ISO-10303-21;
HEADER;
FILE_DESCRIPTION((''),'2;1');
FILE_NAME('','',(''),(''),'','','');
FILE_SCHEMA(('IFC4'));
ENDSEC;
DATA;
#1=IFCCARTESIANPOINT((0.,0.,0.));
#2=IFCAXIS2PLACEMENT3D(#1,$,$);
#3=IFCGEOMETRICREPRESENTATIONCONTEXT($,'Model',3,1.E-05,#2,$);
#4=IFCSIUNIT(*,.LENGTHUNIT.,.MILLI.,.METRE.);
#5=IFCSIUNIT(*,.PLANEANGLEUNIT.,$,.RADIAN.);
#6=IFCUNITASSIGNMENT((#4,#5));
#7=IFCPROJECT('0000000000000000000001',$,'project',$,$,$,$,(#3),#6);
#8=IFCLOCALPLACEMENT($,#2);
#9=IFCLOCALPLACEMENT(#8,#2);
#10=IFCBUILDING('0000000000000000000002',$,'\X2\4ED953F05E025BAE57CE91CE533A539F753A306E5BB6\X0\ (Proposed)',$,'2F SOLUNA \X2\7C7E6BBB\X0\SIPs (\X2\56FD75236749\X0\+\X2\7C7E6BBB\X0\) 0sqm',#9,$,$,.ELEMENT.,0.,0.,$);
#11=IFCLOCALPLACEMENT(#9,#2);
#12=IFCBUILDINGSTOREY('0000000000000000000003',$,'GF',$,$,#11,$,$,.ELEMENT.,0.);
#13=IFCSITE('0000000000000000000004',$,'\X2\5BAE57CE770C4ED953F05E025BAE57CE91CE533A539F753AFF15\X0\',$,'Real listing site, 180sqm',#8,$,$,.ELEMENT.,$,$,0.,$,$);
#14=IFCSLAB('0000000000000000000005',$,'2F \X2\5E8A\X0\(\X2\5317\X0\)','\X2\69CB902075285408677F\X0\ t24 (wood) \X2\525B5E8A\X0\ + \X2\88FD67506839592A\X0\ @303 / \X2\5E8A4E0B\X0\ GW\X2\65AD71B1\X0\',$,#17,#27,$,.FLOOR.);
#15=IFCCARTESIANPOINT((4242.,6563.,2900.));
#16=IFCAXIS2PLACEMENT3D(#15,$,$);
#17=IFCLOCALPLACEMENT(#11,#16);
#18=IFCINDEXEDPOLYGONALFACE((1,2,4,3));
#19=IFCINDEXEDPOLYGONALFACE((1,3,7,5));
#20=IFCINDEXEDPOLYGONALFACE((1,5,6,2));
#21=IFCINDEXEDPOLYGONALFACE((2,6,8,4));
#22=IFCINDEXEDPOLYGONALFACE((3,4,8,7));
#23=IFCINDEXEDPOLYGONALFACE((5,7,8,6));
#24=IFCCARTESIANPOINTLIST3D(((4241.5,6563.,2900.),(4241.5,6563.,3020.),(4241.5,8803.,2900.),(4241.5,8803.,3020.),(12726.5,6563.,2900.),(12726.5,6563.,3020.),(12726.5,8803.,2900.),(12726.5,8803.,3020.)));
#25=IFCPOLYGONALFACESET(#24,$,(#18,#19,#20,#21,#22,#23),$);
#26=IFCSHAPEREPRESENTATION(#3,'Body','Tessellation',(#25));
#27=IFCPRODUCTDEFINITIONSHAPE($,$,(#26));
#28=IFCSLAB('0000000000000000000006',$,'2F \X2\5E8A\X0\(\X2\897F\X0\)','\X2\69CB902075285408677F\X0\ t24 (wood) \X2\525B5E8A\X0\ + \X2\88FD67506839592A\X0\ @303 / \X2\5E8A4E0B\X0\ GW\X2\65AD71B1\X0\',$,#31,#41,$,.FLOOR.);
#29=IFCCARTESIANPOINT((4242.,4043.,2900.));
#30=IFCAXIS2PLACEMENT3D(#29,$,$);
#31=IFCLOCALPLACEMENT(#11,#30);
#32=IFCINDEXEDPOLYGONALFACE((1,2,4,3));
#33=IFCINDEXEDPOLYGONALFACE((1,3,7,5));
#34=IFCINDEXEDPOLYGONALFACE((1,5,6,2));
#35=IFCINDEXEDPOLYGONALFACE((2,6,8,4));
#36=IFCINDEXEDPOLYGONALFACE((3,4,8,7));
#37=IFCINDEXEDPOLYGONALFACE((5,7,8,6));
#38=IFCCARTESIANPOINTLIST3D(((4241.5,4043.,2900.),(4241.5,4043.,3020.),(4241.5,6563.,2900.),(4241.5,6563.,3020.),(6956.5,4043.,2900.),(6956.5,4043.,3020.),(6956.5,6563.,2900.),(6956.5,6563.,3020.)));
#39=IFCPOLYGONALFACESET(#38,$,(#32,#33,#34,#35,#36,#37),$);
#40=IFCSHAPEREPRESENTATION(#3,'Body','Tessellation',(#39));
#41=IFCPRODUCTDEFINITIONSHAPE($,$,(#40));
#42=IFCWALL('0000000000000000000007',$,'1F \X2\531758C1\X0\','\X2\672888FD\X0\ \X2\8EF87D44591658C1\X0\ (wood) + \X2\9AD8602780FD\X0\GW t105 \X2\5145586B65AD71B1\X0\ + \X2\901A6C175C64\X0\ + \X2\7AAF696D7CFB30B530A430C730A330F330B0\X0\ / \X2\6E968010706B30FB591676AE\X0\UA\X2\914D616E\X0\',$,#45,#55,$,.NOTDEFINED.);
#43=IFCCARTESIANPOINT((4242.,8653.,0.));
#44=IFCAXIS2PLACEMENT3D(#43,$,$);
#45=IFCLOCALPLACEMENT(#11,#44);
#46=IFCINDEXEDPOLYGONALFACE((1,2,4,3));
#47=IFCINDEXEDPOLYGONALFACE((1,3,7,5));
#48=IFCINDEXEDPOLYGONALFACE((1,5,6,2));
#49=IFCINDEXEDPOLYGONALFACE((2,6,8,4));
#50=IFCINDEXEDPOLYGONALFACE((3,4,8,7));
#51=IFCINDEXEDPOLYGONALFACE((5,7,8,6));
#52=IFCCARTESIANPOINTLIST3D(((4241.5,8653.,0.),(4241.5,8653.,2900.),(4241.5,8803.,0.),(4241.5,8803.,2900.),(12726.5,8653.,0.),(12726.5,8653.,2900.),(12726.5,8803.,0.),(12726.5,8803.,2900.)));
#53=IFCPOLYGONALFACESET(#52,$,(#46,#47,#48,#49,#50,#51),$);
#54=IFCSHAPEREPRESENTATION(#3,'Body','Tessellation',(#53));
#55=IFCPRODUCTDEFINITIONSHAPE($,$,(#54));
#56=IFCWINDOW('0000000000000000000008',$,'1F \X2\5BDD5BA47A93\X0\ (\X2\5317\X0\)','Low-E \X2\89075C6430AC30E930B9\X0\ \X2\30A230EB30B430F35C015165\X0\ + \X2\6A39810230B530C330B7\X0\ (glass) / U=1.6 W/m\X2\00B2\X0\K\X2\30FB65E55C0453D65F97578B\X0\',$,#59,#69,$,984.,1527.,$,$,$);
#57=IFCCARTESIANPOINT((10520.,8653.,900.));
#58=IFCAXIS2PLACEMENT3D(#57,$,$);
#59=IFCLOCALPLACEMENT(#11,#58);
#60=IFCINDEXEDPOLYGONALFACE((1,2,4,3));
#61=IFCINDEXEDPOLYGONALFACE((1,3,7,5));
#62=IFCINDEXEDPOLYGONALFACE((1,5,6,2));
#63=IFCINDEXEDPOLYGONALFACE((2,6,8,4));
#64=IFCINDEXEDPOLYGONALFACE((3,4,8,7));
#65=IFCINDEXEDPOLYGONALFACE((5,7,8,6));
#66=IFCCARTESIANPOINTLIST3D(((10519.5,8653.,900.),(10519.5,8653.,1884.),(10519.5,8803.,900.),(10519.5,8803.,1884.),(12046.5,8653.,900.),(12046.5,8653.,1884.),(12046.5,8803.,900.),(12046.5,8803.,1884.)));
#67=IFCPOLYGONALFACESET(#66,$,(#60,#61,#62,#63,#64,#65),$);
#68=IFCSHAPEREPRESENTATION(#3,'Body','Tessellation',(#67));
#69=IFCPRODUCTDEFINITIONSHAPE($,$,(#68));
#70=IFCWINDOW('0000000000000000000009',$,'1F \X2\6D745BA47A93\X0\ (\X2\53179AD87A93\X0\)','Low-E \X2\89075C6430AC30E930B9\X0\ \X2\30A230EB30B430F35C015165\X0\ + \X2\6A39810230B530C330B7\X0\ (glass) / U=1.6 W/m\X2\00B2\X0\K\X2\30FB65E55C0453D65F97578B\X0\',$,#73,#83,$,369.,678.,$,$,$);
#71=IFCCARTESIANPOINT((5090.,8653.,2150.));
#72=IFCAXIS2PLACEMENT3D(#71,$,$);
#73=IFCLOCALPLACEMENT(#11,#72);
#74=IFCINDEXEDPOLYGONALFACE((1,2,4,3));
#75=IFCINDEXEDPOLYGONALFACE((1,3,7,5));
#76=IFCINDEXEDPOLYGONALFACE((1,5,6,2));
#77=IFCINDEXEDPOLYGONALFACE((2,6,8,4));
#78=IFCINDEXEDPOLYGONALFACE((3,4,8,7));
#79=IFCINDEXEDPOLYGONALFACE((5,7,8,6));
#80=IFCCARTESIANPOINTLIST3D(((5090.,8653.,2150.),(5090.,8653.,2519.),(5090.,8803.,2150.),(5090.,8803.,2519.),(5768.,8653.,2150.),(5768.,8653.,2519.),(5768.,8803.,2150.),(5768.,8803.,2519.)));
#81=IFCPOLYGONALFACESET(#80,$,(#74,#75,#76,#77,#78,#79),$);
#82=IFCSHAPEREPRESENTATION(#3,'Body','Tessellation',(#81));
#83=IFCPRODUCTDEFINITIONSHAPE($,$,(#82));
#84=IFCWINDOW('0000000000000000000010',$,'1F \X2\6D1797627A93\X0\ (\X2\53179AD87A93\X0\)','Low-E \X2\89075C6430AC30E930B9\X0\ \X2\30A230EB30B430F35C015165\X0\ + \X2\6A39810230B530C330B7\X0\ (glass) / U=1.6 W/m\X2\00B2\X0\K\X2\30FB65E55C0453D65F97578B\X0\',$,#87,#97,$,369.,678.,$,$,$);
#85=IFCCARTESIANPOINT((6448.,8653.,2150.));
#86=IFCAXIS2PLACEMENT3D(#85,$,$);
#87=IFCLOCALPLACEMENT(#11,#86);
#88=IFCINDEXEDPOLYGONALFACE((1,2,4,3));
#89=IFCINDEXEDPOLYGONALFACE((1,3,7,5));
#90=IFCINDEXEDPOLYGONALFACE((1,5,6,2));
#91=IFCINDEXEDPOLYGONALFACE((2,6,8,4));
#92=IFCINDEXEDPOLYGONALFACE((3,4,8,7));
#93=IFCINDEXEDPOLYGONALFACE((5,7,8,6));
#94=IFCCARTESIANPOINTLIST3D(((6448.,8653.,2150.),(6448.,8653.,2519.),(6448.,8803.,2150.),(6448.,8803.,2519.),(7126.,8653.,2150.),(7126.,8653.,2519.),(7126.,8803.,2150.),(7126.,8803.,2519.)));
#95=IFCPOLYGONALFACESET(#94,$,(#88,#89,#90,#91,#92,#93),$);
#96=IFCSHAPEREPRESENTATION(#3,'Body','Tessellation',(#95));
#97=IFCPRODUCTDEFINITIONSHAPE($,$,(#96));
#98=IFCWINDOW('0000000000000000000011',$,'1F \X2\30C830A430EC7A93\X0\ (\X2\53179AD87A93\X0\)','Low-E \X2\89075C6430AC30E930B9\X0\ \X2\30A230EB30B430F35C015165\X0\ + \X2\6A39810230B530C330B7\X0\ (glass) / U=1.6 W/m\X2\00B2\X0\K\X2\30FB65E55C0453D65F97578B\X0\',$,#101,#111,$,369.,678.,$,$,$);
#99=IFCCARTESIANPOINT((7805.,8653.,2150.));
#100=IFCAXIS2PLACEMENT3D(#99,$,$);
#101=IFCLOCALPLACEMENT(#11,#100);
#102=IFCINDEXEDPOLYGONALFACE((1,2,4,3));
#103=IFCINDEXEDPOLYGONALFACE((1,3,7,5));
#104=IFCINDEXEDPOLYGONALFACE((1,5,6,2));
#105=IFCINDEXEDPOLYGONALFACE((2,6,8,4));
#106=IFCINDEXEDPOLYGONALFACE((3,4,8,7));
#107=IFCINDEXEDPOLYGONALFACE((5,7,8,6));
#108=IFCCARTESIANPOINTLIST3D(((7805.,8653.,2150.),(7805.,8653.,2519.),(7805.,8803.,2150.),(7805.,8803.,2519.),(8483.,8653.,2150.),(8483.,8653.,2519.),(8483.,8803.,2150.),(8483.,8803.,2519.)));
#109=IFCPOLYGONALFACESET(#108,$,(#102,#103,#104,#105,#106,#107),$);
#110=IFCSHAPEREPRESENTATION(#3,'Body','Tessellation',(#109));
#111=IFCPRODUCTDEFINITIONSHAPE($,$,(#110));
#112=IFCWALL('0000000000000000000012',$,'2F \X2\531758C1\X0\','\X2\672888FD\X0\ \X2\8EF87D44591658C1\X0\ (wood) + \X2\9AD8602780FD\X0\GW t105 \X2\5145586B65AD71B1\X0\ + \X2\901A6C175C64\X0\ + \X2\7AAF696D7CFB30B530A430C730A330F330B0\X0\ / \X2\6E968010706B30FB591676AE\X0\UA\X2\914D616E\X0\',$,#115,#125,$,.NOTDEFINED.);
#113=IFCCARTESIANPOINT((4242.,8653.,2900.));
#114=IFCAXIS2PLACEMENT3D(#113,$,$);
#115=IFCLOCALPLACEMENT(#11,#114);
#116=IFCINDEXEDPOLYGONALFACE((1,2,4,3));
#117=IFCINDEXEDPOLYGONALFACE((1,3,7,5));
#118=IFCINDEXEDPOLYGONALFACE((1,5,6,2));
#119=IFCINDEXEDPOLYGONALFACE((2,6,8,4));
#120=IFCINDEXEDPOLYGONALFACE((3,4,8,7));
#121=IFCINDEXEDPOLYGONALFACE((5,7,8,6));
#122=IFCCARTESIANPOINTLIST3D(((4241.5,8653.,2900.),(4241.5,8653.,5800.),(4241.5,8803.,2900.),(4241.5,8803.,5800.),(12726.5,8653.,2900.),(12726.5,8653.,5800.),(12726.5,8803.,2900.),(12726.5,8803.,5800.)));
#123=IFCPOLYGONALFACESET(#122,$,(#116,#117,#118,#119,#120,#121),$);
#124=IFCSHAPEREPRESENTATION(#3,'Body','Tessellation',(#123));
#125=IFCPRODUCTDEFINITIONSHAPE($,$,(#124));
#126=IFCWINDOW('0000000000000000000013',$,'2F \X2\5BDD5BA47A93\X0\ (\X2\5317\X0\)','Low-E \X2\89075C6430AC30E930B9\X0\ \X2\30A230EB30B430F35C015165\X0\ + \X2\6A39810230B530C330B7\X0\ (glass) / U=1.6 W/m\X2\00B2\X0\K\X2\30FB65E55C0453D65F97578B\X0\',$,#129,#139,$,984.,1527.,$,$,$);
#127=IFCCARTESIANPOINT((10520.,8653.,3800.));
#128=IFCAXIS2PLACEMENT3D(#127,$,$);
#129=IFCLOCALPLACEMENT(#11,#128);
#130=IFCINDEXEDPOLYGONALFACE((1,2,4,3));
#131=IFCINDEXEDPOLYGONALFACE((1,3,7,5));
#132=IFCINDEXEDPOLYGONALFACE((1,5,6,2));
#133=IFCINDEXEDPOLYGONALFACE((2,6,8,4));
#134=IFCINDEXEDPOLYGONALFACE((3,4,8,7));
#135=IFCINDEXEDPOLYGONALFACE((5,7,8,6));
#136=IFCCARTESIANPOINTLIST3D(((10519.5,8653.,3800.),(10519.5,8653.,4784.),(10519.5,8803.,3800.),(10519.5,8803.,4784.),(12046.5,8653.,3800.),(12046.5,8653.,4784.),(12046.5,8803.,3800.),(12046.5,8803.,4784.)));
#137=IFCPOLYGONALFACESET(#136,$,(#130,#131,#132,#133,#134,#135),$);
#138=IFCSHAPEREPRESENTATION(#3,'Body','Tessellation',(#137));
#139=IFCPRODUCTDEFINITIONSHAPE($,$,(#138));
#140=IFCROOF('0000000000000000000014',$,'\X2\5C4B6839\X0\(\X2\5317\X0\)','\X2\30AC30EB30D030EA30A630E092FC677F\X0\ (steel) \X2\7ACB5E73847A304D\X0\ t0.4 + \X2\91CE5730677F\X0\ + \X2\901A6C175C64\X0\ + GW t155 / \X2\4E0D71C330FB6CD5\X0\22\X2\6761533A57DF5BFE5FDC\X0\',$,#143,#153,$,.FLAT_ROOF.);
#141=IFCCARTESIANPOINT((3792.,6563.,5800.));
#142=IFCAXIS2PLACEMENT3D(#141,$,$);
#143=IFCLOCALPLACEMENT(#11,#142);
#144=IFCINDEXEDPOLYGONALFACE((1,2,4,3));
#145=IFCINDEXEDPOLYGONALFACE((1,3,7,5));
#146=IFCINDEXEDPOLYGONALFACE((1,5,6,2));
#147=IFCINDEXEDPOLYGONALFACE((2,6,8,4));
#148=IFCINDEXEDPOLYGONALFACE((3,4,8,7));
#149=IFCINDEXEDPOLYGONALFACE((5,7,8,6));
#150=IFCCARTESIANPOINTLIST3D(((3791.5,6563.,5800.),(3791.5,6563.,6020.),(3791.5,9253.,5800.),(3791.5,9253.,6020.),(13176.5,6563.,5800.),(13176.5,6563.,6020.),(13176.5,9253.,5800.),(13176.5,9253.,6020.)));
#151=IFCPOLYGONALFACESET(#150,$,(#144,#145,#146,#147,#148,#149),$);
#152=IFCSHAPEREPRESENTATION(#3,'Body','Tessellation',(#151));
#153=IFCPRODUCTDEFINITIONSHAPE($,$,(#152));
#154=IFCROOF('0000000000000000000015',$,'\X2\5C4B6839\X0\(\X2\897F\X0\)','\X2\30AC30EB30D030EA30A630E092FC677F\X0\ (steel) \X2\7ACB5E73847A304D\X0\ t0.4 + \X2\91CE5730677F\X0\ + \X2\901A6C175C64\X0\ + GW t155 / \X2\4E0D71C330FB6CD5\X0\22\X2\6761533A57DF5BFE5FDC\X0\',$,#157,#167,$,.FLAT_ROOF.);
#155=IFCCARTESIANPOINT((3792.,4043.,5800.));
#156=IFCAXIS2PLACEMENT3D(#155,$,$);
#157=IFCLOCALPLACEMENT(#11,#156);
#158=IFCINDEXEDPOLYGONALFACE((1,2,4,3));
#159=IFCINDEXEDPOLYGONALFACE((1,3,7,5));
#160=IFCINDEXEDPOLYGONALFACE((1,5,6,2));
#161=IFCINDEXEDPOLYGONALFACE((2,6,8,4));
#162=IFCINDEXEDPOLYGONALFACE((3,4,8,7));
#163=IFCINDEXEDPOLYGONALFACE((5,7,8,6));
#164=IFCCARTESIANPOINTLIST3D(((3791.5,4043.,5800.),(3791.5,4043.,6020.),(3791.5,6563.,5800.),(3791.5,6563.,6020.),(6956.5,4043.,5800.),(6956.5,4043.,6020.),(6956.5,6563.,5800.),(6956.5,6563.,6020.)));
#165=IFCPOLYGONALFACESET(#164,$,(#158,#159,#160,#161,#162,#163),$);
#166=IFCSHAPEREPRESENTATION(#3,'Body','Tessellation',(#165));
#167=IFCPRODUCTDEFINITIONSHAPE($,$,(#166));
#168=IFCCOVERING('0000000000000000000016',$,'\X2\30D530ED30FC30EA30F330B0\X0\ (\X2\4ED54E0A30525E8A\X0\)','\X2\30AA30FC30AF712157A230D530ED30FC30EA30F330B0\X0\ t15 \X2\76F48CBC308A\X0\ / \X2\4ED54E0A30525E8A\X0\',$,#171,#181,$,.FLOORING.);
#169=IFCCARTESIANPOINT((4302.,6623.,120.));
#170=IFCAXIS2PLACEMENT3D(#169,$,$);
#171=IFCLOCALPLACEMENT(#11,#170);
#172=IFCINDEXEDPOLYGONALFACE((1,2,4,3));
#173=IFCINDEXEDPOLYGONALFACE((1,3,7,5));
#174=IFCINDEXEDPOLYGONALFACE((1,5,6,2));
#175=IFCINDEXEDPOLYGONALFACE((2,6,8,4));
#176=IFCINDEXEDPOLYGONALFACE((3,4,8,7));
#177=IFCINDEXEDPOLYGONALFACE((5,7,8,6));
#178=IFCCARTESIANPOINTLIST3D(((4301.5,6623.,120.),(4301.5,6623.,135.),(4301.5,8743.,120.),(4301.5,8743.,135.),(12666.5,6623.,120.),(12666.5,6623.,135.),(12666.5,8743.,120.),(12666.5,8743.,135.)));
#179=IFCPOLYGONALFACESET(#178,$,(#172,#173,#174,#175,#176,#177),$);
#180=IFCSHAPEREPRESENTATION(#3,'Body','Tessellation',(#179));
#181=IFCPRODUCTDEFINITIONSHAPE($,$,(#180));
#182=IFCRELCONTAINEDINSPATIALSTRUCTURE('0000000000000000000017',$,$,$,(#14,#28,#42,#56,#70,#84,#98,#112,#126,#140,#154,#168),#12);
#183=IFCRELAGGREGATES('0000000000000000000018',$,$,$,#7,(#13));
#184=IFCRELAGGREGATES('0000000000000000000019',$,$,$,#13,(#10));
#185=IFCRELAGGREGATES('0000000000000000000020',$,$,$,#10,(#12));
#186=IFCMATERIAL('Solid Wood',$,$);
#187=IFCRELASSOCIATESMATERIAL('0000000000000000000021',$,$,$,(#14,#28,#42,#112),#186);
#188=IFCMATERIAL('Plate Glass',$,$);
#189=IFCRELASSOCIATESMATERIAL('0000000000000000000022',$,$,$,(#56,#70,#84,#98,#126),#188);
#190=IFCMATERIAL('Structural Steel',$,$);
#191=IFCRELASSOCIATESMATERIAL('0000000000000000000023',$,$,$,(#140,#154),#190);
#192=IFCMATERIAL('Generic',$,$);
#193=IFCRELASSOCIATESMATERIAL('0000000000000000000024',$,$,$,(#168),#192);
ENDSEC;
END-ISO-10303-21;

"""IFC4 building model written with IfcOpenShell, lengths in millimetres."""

from ifc_helpers import new_model, si_unit, frame, frame_2d, origin, place, context, project, spatial, rectangle, extrude, material, element, fill, save


model = new_model("IFC4")

# Units and contexts
model_context = context("Model", 3, precision=1e-05, world=origin())
ifc_project = project(units=[si_unit("LENGTHUNIT", "METRE", prefix="MILLI"), si_unit("PLANEANGLEUNIT", "RADIAN")], contexts=[model_context])

# Site, building, storey
site_placement = place(None, origin())
site = spatial("IfcSite", under=ifc_project, at=site_placement, Name="宮城県仙台市宮城野区原町５", ObjectType="Real listing site, 180sqm", CompositionType="ELEMENT", RefElevation=0.0)
building_placement = place(site_placement, origin())
building = spatial("IfcBuilding", under=site, at=building_placement, Name="仙台市宮城野区原町の家 (Proposed)", ObjectType="2F SOLUNA 籾殻SIPs (国産杉+籾殻) 0sqm", CompositionType="ELEMENT", ElevationOfRefHeight=0.0, ElevationOfTerrain=0.0)
storey_placement = place(building_placement, origin())
storey = spatial("IfcBuildingStorey", under=building, at=storey_placement, Name="GF", CompositionType="ELEMENT", Elevation=0.0)

# Slabs
ifc_material_1 = material(Name="Solid Wood")
slab_1_placement = place(storey_placement, frame((4242.0, 6563.0, 2900.0)))
element("IfcSlab", 1, at=slab_1_placement, inside=storey, material=ifc_material_1, Name="2F 床(北)", Description="構造用合板 t24 (wood) 剛床 + 製材根太 @303 / 床下 GW断熱", PredefinedType="FLOOR", context=model_context, shape_type="SweptSolid", body=[
    extrude(rectangle(XDim=8485.0, YDim=2240.0, at=frame_2d((4242.0, 1120.0))), frame((4242.0, 6563.0, 2900.0)), (0.0, 0.0, 1.0), 120.0),
])
slab_2_placement = place(storey_placement, frame((4242.0, 4043.0, 2900.0)))
element("IfcSlab", 2, at=slab_2_placement, inside=storey, material=ifc_material_1, Name="2F 床(西)", Description="構造用合板 t24 (wood) 剛床 + 製材根太 @303 / 床下 GW断熱", PredefinedType="FLOOR", context=model_context, shape_type="SweptSolid", body=[
    extrude(rectangle(XDim=2715.0, YDim=2520.0, at=frame_2d((1357.0, 1260.0))), frame((4242.0, 4043.0, 2900.0)), (0.0, 0.0, 1.0), 120.0),
])

# Wall, openings, windows
wall_1_placement = place(storey_placement, frame((4242.0, 8653.0, 0.0)))
wall_1 = element("IfcWall", 3, at=wall_1_placement, inside=storey, material=ifc_material_1, Name="1F 北壁", Description="木製 軸組外壁 (wood) + 高性能GW t105 充填断熱 + 通気層 + 窯業系サイディング / 準耐火・外皮UA配慮", PredefinedType="NOTDEFINED", context=model_context, shape_type="SweptSolid", body=[
    extrude(rectangle(XDim=8485.0, YDim=150.0, at=frame_2d((4242.0, 75.0))), frame((4242.0, 8653.0, 0.0)), (0.0, 0.0, 1.0), 2900.0),
])
opening_1_placement = place(storey_placement, frame((10520.0, 8653.0, 900.0)))
opening_1 = element("IfcOpeningElement", 4, at=opening_1_placement, cuts=wall_1, PredefinedType="NOTDEFINED", context=model_context, shape_type="SweptSolid", body=[
    extrude(rectangle(XDim=1527.0, YDim=150.0, at=frame_2d((763.0, 75.0))), frame((10520.0, 8653.0, 900.0)), (0.0, 0.0, 1.0), 984.0),
])
opening_2_placement = place(storey_placement, frame((5090.0, 8653.0, 2150.0)))
opening_2 = element("IfcOpeningElement", 5, at=opening_2_placement, cuts=wall_1, PredefinedType="NOTDEFINED", context=model_context, shape_type="SweptSolid", body=[
    extrude(rectangle(XDim=678.0, YDim=150.0, at=frame_2d((339.0, 75.0))), frame((5090.0, 8653.0, 2150.0)), (0.0, 0.0, 1.0), 369.0),
])
opening_3_placement = place(storey_placement, frame((6448.0, 8653.0, 2150.0)))
opening_3 = element("IfcOpeningElement", 6, at=opening_3_placement, cuts=wall_1, PredefinedType="NOTDEFINED", context=model_context, shape_type="SweptSolid", body=[
    extrude(rectangle(XDim=678.0, YDim=150.0, at=frame_2d((339.0, 75.0))), frame((6448.0, 8653.0, 2150.0)), (0.0, 0.0, 1.0), 369.0),
])
opening_4_placement = place(storey_placement, frame((7805.0, 8653.0, 2150.0)))
opening_4 = element("IfcOpeningElement", 7, at=opening_4_placement, cuts=wall_1, PredefinedType="NOTDEFINED", context=model_context, shape_type="SweptSolid", body=[
    extrude(rectangle(XDim=678.0, YDim=150.0, at=frame_2d((339.0, 75.0))), frame((7805.0, 8653.0, 2150.0)), (0.0, 0.0, 1.0), 369.0),
])
ifc_material_2 = material(Name="Plate Glass")
window_1_placement = place(storey_placement, frame((10520.0, 8653.0, 900.0)))
window_1 = element("IfcWindow", 8, at=window_1_placement, inside=storey, material=ifc_material_2, Name="1F 寝室窓 (北)", Description="Low-E 複層ガラス アルゴン封入 + 樹脂サッシ (glass) / U=1.6 W/m²K・日射取得型", OverallHeight=984.0, OverallWidth=1527.0, context=model_context, shape_type="SweptSolid", body=[
    extrude(rectangle(XDim=1527.0, YDim=150.0, at=frame_2d((763.0, 75.0))), frame((10520.0, 8653.0, 900.0)), (0.0, 0.0, 1.0), 984.0),
])
fill(opening_1, window_1)
window_2_placement = place(storey_placement, frame((5090.0, 8653.0, 2150.0)))
window_2 = element("IfcWindow", 9, at=window_2_placement, inside=storey, material=ifc_material_2, Name="1F 浴室窓 (北高窓)", Description="Low-E 複層ガラス アルゴン封入 + 樹脂サッシ (glass) / U=1.6 W/m²K・日射取得型", OverallHeight=369.0, OverallWidth=678.0, context=model_context, shape_type="SweptSolid", body=[
    extrude(rectangle(XDim=678.0, YDim=150.0, at=frame_2d((339.0, 75.0))), frame((5090.0, 8653.0, 2150.0)), (0.0, 0.0, 1.0), 369.0),
])
fill(opening_2, window_2)
window_3_placement = place(storey_placement, frame((6448.0, 8653.0, 2150.0)))
window_3 = element("IfcWindow", 10, at=window_3_placement, inside=storey, material=ifc_material_2, Name="1F 洗面窓 (北高窓)", Description="Low-E 複層ガラス アルゴン封入 + 樹脂サッシ (glass) / U=1.6 W/m²K・日射取得型", OverallHeight=369.0, OverallWidth=678.0, context=model_context, shape_type="SweptSolid", body=[
    extrude(rectangle(XDim=678.0, YDim=150.0, at=frame_2d((339.0, 75.0))), frame((6448.0, 8653.0, 2150.0)), (0.0, 0.0, 1.0), 369.0),
])
fill(opening_3, window_3)
window_4_placement = place(storey_placement, frame((7805.0, 8653.0, 2150.0)))
window_4 = element("IfcWindow", 11, at=window_4_placement, inside=storey, material=ifc_material_2, Name="1F トイレ窓 (北高窓)", Description="Low-E 複層ガラス アルゴン封入 + 樹脂サッシ (glass) / U=1.6 W/m²K・日射取得型", OverallHeight=369.0, OverallWidth=678.0, context=model_context, shape_type="SweptSolid", body=[
    extrude(rectangle(XDim=678.0, YDim=150.0, at=frame_2d((339.0, 75.0))), frame((7805.0, 8653.0, 2150.0)), (0.0, 0.0, 1.0), 369.0),
])
fill(opening_4, window_4)

# Wall, opening, window
wall_2_placement = place(storey_placement, frame((4242.0, 8653.0, 2900.0)))
wall_2 = element("IfcWall", 12, at=wall_2_placement, inside=storey, material=ifc_material_1, Name="2F 北壁", Description="木製 軸組外壁 (wood) + 高性能GW t105 充填断熱 + 通気層 + 窯業系サイディング / 準耐火・外皮UA配慮", PredefinedType="NOTDEFINED", context=model_context, shape_type="SweptSolid", body=[
    extrude(rectangle(XDim=8485.0, YDim=150.0, at=frame_2d((4242.0, 75.0))), frame((4242.0, 8653.0, 2900.0)), (0.0, 0.0, 1.0), 2900.0),
])
opening_5_placement = place(storey_placement, frame((10520.0, 8653.0, 3800.0)))
opening_5 = element("IfcOpeningElement", 13, at=opening_5_placement, cuts=wall_2, PredefinedType="NOTDEFINED", context=model_context, shape_type="SweptSolid", body=[
    extrude(rectangle(XDim=1527.0, YDim=150.0, at=frame_2d((763.0, 75.0))), frame((10520.0, 8653.0, 3800.0)), (0.0, 0.0, 1.0), 984.0),
])
window_5_placement = place(storey_placement, frame((10520.0, 8653.0, 3800.0)))
window_5 = element("IfcWindow", 14, at=window_5_placement, inside=storey, material=ifc_material_2, Name="2F 寝室窓 (北)", Description="Low-E 複層ガラス アルゴン封入 + 樹脂サッシ (glass) / U=1.6 W/m²K・日射取得型", OverallHeight=984.0, OverallWidth=1527.0, context=model_context, shape_type="SweptSolid", body=[
    extrude(rectangle(XDim=1527.0, YDim=150.0, at=frame_2d((763.0, 75.0))), frame((10520.0, 8653.0, 3800.0)), (0.0, 0.0, 1.0), 984.0),
])
fill(opening_5, window_5)

# Roofs
ifc_material_3 = material(Name="Structural Steel")
for number, where, name in (
    (15, (3792.0, 6563.0, 5800.0), "屋根(北)"),
):
    element("IfcRoof", number, at=place(storey_placement, frame(where)), inside=storey, material=ifc_material_3, Name=name, Description="ガルバリウム鋼板 (steel) 立平葺き t0.4 + 野地板 + 通気層 + GW t155 / 不燃・法22条区域対応", PredefinedType="FLAT_ROOF", context=model_context, shape_type="SweptSolid", body=[
        extrude(rectangle(XDim=9385.0, YDim=2690.0, at=frame_2d((4692.0, 1345.0))), frame((3792.0, 6563.0, 5800.0)), (0.0, 0.0, 1.0), 220.0),
    ])
roof_placement = place(storey_placement, frame((3792.0, 4043.0, 5800.0)))
element("IfcRoof", 16, at=roof_placement, inside=storey, material=ifc_material_3, Name="屋根(西)", Description="ガルバリウム鋼板 (steel) 立平葺き t0.4 + 野地板 + 通気層 + GW t155 / 不燃・法22条区域対応", PredefinedType="FLAT_ROOF", context=model_context, shape_type="SweptSolid", body=[
    extrude(rectangle(XDim=3165.0, YDim=2520.0, at=frame_2d((1582.0, 1260.0))), frame((3792.0, 4043.0, 5800.0)), (0.0, 0.0, 1.0), 220.0),
])

# Covering
ifc_material_4 = material(Name="Generic")
covering_1_placement = place(storey_placement, frame((4302.0, 6623.0, 120.0)))
element("IfcCovering", 17, at=covering_1_placement, inside=storey, material=ifc_material_4, Name="フローリング (仕上げ床)", Description="オーク無垢フローリング t15 直貼り / 仕上げ床", PredefinedType="FLOORING", context=model_context, shape_type="SweptSolid", body=[
    extrude(rectangle(XDim=8365.0, YDim=2120.0, at=frame_2d((4182.0, 1060.0))), frame((4302.0, 6623.0, 120.0)), (0.0, 0.0, 1.0), 15.0),
])

save(model, "model.ifc")
